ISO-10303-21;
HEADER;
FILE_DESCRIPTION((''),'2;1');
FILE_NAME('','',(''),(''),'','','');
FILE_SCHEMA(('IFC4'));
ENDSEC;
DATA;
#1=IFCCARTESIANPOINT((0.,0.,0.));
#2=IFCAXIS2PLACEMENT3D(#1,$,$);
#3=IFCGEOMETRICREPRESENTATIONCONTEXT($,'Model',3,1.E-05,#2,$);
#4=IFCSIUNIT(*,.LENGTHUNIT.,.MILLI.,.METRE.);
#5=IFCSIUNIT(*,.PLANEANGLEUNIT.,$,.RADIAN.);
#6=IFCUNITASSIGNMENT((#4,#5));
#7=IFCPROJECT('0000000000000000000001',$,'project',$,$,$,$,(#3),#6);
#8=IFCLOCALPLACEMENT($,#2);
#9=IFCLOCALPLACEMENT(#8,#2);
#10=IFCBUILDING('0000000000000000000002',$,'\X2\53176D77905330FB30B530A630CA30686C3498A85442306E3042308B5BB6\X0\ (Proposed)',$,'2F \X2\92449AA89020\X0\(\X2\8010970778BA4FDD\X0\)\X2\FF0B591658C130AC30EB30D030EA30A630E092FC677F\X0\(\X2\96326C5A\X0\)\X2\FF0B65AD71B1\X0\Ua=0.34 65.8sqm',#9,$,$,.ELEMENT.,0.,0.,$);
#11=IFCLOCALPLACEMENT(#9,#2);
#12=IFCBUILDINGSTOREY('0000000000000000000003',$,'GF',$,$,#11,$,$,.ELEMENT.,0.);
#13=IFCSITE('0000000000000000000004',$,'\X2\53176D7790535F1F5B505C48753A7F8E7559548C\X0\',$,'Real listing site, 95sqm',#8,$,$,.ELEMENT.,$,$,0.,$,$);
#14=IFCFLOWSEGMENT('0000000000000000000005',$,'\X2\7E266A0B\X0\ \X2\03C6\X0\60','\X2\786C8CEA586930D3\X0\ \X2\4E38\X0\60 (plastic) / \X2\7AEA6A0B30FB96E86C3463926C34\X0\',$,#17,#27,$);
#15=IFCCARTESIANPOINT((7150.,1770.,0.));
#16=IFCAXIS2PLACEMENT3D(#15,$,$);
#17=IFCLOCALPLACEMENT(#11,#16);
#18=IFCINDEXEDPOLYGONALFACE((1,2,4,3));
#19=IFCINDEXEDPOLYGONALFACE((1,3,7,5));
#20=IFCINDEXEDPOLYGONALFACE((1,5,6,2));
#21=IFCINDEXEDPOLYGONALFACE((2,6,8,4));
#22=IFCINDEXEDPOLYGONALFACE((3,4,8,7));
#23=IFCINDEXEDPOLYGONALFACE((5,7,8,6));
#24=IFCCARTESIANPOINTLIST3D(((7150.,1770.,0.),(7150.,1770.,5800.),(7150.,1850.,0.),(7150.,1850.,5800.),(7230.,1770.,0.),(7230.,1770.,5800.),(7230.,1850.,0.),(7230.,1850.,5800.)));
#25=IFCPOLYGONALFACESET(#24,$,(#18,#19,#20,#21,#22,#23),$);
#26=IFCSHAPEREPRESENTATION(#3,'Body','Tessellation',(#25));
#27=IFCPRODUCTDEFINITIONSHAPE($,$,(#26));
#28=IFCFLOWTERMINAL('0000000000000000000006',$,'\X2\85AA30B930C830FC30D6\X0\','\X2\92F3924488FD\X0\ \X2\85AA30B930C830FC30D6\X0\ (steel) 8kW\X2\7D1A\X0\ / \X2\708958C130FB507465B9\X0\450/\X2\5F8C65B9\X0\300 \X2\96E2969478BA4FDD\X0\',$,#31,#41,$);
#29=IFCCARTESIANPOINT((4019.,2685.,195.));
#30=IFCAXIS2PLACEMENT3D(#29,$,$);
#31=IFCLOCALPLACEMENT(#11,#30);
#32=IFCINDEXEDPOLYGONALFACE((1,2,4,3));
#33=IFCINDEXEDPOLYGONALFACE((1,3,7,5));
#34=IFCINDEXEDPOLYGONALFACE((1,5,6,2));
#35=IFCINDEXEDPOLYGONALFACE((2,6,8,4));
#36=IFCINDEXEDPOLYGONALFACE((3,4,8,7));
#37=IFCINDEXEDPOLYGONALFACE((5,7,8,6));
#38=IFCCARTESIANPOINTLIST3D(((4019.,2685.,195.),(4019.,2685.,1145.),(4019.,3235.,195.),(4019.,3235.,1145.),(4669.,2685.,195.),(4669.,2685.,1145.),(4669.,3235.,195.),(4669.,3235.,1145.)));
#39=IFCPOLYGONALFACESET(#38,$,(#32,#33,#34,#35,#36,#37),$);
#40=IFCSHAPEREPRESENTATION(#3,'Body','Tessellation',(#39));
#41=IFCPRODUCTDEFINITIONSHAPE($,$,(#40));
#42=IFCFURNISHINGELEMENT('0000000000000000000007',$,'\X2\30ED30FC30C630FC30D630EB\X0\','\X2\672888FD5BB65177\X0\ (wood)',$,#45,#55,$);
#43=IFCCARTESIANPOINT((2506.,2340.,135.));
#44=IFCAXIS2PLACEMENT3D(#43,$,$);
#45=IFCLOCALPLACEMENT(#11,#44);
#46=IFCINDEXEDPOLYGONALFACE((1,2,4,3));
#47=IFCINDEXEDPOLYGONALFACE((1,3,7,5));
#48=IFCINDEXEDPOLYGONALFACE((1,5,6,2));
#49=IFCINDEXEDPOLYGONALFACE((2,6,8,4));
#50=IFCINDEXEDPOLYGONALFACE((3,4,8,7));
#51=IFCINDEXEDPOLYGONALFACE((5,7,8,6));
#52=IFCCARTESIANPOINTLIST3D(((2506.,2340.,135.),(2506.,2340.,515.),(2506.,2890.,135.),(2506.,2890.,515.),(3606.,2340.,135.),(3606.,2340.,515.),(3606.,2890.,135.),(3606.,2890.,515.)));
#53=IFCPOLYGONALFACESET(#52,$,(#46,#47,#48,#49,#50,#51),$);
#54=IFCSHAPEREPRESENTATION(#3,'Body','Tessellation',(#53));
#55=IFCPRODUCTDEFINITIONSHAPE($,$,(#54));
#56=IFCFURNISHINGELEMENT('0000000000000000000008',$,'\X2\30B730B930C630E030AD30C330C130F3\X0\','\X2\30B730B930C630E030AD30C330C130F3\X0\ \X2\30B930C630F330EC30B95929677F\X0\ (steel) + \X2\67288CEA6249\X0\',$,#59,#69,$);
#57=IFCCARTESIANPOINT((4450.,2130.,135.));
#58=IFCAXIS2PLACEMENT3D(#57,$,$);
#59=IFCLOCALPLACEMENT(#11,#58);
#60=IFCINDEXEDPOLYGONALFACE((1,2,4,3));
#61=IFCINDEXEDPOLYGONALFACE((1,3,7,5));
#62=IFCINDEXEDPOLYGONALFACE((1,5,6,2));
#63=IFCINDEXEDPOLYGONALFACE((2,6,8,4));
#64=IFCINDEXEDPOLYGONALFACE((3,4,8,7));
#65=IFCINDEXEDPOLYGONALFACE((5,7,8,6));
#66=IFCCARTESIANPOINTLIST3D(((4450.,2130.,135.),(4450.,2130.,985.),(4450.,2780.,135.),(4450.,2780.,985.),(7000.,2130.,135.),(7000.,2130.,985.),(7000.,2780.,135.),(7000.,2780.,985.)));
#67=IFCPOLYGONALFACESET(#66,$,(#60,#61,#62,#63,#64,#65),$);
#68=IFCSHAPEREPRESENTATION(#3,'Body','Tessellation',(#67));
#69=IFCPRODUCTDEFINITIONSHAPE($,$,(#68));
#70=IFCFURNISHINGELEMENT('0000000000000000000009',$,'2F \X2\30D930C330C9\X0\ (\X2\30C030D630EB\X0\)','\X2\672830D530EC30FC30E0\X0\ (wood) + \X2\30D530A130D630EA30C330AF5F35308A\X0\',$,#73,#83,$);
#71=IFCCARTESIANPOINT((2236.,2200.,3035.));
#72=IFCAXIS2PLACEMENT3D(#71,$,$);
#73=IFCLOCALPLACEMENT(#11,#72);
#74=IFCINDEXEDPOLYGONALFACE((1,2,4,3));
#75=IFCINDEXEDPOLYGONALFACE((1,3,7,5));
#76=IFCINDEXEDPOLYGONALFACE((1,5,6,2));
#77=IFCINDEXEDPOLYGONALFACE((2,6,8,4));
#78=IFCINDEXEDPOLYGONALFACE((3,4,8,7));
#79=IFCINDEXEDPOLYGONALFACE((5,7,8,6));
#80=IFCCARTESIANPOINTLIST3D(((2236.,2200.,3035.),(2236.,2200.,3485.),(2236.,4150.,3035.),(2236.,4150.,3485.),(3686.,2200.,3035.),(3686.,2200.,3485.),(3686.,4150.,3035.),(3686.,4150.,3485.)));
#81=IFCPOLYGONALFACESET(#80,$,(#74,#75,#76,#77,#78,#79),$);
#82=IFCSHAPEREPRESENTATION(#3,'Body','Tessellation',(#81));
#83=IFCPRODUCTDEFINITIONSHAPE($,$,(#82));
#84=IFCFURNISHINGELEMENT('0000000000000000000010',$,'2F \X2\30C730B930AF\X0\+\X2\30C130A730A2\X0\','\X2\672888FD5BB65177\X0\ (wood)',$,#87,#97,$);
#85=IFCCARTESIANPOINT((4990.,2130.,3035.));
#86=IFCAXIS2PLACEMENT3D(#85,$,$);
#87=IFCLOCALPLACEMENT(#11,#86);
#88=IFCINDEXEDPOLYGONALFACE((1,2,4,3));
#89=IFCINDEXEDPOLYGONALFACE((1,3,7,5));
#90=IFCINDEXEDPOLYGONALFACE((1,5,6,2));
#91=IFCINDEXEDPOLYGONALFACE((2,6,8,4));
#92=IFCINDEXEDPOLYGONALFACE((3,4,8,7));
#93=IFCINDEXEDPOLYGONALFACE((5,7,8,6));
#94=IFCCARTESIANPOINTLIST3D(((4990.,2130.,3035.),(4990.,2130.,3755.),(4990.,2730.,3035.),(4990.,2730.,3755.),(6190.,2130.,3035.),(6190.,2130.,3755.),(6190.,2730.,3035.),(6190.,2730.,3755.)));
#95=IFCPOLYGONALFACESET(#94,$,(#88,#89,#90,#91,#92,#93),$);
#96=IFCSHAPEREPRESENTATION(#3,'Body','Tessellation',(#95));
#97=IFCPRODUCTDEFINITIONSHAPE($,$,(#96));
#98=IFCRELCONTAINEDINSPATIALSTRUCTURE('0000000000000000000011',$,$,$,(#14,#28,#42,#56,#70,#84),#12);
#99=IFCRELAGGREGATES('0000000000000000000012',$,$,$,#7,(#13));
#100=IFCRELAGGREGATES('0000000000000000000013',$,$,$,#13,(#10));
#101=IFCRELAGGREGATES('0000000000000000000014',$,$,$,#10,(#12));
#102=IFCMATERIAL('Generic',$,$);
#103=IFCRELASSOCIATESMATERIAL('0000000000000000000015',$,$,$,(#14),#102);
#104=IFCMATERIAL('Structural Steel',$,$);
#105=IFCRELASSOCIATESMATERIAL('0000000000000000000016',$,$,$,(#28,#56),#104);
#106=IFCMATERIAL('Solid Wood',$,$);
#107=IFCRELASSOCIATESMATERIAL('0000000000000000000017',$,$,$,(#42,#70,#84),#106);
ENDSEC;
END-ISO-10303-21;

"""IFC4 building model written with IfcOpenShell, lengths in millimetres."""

from ifc_helpers import new_model, si_unit, frame, frame_2d, origin, place, context, project, spatial, rectangle, extrude, material, element, save


model = new_model("IFC4")

# Units and contexts
model_context = context("Model", 3, precision=1e-05, world=origin())
ifc_project = project(units=[si_unit("LENGTHUNIT", "METRE", prefix="MILLI"), si_unit("PLANEANGLEUNIT", "RADIAN")], contexts=[model_context])

# Site, building, storey
site_placement = place(None, origin())
site = spatial("IfcSite", under=ifc_project, at=site_placement, Name="北海道弟子屈町美留和", ObjectType="Real listing site, 95sqm", CompositionType="ELEMENT", RefElevation=0.0)
building_placement = place(site_placement, origin())
building = spatial("IfcBuilding", under=site, at=building_placement, Name="北海道・サウナと水風呂のある家 (Proposed)", ObjectType="2F 鉄骨造(耐震確保)＋外壁ガルバリウム鋼板(防汚)＋断熱Ua=0.34 65.8sqm", CompositionType="ELEMENT", ElevationOfRefHeight=0.0, ElevationOfTerrain=0.0)
storey_placement = place(building_placement, origin())
storey = spatial("IfcBuildingStorey", under=building, at=storey_placement, Name="GF", CompositionType="ELEMENT", Elevation=0.0)

# Shared definitions
ifc_material_1 = material(Name="Solid Wood")

# Shared definitions
ifc_material_2 = material(Name="Structural Steel")

# Shared definitions
ifc_material_3 = material(Name="Generic")

# Flow segment
flow_segment_placement = place(storey_placement, frame((7150.0, 1770.0, 0.0)))
element("IfcFlowSegment", 1, at=flow_segment_placement, inside=storey, material=ifc_material_3, Name="縦樋 φ60", Description="硬質塩ビ 丸60 (plastic) / 竪樋・雨水排水", context=model_context, shape_type="SweptSolid", body=[
    extrude(rectangle(XDim=80.0, YDim=80.0, at=frame_2d((40.0, 40.0))), frame((7150.0, 1770.0, 0.0)), (0.0, 0.0, 1.0), 5800.0),
])

# Flow terminal
flow_terminal_1_placement = place(storey_placement, frame((4019.0, 2685.0, 195.0)))
element("IfcFlowTerminal", 2, at=flow_terminal_1_placement, inside=storey, material=ifc_material_2, Name="薪ストーブ", Description="鋳鉄製 薪ストーブ (steel) 8kW級 / 炉壁・側方450/後方300 離隔確保", context=model_context, shape_type="SweptSolid", body=[
    extrude(rectangle(XDim=650.0, YDim=550.0, at=frame_2d((325.0, 275.0))), frame((4019.0, 2685.0, 195.0)), (0.0, 0.0, 1.0), 950.0),
])

# Furnishing elements
furnishing_1_placement = place(storey_placement, frame((2506.0, 2340.0, 135.0)))
element("IfcFurnishingElement", 3, at=furnishing_1_placement, inside=storey, material=ifc_material_1, Name="ローテーブル", Description="木製家具 (wood)", context=model_context, shape_type="SweptSolid", body=[
    extrude(rectangle(XDim=1100.0, YDim=550.0, at=frame_2d((550.0, 275.0))), frame((2506.0, 2340.0, 135.0)), (0.0, 0.0, 1.0), 380.0),
])
furnishing_2_placement = place(storey_placement, frame((4450.0, 2130.0, 135.0)))
element("IfcFurnishingElement", 4, at=furnishing_2_placement, inside=storey, material=ifc_material_2, Name="システムキッチン", Description="システムキッチン ステンレス天板 (steel) + 木質扉", context=model_context, shape_type="SweptSolid", body=[
    extrude(rectangle(XDim=2550.0, YDim=650.0, at=frame_2d((1275.0, 325.0))), frame((4450.0, 2130.0, 135.0)), (0.0, 0.0, 1.0), 850.0),
])
furnishing_3_placement = place(storey_placement, frame((2236.0, 2200.0, 3035.0)))
element("IfcFurnishingElement", 5, at=furnishing_3_placement, inside=storey, material=ifc_material_1, Name="2F ベッド (ダブル)", Description="木フレーム (wood) + ファブリック張り", context=model_context, shape_type="SweptSolid", body=[
    extrude(rectangle(XDim=1450.0, YDim=1950.0, at=frame_2d((725.0, 975.0))), frame((2236.0, 2200.0, 3035.0)), (0.0, 0.0, 1.0), 450.0),
])
furnishing_4_placement = place(storey_placement, frame((4990.0, 2130.0, 3035.0)))
element("IfcFurnishingElement", 6, at=furnishing_4_placement, inside=storey, material=ifc_material_1, Name="2F デスク+チェア", Description="木製家具 (wood)", context=model_context, shape_type="SweptSolid", body=[
    extrude(rectangle(XDim=1200.0, YDim=600.0, at=frame_2d((600.0, 300.0))), frame((4990.0, 2130.0, 3035.0)), (0.0, 0.0, 1.0), 720.0),
])

save(model, "model.ifc")
